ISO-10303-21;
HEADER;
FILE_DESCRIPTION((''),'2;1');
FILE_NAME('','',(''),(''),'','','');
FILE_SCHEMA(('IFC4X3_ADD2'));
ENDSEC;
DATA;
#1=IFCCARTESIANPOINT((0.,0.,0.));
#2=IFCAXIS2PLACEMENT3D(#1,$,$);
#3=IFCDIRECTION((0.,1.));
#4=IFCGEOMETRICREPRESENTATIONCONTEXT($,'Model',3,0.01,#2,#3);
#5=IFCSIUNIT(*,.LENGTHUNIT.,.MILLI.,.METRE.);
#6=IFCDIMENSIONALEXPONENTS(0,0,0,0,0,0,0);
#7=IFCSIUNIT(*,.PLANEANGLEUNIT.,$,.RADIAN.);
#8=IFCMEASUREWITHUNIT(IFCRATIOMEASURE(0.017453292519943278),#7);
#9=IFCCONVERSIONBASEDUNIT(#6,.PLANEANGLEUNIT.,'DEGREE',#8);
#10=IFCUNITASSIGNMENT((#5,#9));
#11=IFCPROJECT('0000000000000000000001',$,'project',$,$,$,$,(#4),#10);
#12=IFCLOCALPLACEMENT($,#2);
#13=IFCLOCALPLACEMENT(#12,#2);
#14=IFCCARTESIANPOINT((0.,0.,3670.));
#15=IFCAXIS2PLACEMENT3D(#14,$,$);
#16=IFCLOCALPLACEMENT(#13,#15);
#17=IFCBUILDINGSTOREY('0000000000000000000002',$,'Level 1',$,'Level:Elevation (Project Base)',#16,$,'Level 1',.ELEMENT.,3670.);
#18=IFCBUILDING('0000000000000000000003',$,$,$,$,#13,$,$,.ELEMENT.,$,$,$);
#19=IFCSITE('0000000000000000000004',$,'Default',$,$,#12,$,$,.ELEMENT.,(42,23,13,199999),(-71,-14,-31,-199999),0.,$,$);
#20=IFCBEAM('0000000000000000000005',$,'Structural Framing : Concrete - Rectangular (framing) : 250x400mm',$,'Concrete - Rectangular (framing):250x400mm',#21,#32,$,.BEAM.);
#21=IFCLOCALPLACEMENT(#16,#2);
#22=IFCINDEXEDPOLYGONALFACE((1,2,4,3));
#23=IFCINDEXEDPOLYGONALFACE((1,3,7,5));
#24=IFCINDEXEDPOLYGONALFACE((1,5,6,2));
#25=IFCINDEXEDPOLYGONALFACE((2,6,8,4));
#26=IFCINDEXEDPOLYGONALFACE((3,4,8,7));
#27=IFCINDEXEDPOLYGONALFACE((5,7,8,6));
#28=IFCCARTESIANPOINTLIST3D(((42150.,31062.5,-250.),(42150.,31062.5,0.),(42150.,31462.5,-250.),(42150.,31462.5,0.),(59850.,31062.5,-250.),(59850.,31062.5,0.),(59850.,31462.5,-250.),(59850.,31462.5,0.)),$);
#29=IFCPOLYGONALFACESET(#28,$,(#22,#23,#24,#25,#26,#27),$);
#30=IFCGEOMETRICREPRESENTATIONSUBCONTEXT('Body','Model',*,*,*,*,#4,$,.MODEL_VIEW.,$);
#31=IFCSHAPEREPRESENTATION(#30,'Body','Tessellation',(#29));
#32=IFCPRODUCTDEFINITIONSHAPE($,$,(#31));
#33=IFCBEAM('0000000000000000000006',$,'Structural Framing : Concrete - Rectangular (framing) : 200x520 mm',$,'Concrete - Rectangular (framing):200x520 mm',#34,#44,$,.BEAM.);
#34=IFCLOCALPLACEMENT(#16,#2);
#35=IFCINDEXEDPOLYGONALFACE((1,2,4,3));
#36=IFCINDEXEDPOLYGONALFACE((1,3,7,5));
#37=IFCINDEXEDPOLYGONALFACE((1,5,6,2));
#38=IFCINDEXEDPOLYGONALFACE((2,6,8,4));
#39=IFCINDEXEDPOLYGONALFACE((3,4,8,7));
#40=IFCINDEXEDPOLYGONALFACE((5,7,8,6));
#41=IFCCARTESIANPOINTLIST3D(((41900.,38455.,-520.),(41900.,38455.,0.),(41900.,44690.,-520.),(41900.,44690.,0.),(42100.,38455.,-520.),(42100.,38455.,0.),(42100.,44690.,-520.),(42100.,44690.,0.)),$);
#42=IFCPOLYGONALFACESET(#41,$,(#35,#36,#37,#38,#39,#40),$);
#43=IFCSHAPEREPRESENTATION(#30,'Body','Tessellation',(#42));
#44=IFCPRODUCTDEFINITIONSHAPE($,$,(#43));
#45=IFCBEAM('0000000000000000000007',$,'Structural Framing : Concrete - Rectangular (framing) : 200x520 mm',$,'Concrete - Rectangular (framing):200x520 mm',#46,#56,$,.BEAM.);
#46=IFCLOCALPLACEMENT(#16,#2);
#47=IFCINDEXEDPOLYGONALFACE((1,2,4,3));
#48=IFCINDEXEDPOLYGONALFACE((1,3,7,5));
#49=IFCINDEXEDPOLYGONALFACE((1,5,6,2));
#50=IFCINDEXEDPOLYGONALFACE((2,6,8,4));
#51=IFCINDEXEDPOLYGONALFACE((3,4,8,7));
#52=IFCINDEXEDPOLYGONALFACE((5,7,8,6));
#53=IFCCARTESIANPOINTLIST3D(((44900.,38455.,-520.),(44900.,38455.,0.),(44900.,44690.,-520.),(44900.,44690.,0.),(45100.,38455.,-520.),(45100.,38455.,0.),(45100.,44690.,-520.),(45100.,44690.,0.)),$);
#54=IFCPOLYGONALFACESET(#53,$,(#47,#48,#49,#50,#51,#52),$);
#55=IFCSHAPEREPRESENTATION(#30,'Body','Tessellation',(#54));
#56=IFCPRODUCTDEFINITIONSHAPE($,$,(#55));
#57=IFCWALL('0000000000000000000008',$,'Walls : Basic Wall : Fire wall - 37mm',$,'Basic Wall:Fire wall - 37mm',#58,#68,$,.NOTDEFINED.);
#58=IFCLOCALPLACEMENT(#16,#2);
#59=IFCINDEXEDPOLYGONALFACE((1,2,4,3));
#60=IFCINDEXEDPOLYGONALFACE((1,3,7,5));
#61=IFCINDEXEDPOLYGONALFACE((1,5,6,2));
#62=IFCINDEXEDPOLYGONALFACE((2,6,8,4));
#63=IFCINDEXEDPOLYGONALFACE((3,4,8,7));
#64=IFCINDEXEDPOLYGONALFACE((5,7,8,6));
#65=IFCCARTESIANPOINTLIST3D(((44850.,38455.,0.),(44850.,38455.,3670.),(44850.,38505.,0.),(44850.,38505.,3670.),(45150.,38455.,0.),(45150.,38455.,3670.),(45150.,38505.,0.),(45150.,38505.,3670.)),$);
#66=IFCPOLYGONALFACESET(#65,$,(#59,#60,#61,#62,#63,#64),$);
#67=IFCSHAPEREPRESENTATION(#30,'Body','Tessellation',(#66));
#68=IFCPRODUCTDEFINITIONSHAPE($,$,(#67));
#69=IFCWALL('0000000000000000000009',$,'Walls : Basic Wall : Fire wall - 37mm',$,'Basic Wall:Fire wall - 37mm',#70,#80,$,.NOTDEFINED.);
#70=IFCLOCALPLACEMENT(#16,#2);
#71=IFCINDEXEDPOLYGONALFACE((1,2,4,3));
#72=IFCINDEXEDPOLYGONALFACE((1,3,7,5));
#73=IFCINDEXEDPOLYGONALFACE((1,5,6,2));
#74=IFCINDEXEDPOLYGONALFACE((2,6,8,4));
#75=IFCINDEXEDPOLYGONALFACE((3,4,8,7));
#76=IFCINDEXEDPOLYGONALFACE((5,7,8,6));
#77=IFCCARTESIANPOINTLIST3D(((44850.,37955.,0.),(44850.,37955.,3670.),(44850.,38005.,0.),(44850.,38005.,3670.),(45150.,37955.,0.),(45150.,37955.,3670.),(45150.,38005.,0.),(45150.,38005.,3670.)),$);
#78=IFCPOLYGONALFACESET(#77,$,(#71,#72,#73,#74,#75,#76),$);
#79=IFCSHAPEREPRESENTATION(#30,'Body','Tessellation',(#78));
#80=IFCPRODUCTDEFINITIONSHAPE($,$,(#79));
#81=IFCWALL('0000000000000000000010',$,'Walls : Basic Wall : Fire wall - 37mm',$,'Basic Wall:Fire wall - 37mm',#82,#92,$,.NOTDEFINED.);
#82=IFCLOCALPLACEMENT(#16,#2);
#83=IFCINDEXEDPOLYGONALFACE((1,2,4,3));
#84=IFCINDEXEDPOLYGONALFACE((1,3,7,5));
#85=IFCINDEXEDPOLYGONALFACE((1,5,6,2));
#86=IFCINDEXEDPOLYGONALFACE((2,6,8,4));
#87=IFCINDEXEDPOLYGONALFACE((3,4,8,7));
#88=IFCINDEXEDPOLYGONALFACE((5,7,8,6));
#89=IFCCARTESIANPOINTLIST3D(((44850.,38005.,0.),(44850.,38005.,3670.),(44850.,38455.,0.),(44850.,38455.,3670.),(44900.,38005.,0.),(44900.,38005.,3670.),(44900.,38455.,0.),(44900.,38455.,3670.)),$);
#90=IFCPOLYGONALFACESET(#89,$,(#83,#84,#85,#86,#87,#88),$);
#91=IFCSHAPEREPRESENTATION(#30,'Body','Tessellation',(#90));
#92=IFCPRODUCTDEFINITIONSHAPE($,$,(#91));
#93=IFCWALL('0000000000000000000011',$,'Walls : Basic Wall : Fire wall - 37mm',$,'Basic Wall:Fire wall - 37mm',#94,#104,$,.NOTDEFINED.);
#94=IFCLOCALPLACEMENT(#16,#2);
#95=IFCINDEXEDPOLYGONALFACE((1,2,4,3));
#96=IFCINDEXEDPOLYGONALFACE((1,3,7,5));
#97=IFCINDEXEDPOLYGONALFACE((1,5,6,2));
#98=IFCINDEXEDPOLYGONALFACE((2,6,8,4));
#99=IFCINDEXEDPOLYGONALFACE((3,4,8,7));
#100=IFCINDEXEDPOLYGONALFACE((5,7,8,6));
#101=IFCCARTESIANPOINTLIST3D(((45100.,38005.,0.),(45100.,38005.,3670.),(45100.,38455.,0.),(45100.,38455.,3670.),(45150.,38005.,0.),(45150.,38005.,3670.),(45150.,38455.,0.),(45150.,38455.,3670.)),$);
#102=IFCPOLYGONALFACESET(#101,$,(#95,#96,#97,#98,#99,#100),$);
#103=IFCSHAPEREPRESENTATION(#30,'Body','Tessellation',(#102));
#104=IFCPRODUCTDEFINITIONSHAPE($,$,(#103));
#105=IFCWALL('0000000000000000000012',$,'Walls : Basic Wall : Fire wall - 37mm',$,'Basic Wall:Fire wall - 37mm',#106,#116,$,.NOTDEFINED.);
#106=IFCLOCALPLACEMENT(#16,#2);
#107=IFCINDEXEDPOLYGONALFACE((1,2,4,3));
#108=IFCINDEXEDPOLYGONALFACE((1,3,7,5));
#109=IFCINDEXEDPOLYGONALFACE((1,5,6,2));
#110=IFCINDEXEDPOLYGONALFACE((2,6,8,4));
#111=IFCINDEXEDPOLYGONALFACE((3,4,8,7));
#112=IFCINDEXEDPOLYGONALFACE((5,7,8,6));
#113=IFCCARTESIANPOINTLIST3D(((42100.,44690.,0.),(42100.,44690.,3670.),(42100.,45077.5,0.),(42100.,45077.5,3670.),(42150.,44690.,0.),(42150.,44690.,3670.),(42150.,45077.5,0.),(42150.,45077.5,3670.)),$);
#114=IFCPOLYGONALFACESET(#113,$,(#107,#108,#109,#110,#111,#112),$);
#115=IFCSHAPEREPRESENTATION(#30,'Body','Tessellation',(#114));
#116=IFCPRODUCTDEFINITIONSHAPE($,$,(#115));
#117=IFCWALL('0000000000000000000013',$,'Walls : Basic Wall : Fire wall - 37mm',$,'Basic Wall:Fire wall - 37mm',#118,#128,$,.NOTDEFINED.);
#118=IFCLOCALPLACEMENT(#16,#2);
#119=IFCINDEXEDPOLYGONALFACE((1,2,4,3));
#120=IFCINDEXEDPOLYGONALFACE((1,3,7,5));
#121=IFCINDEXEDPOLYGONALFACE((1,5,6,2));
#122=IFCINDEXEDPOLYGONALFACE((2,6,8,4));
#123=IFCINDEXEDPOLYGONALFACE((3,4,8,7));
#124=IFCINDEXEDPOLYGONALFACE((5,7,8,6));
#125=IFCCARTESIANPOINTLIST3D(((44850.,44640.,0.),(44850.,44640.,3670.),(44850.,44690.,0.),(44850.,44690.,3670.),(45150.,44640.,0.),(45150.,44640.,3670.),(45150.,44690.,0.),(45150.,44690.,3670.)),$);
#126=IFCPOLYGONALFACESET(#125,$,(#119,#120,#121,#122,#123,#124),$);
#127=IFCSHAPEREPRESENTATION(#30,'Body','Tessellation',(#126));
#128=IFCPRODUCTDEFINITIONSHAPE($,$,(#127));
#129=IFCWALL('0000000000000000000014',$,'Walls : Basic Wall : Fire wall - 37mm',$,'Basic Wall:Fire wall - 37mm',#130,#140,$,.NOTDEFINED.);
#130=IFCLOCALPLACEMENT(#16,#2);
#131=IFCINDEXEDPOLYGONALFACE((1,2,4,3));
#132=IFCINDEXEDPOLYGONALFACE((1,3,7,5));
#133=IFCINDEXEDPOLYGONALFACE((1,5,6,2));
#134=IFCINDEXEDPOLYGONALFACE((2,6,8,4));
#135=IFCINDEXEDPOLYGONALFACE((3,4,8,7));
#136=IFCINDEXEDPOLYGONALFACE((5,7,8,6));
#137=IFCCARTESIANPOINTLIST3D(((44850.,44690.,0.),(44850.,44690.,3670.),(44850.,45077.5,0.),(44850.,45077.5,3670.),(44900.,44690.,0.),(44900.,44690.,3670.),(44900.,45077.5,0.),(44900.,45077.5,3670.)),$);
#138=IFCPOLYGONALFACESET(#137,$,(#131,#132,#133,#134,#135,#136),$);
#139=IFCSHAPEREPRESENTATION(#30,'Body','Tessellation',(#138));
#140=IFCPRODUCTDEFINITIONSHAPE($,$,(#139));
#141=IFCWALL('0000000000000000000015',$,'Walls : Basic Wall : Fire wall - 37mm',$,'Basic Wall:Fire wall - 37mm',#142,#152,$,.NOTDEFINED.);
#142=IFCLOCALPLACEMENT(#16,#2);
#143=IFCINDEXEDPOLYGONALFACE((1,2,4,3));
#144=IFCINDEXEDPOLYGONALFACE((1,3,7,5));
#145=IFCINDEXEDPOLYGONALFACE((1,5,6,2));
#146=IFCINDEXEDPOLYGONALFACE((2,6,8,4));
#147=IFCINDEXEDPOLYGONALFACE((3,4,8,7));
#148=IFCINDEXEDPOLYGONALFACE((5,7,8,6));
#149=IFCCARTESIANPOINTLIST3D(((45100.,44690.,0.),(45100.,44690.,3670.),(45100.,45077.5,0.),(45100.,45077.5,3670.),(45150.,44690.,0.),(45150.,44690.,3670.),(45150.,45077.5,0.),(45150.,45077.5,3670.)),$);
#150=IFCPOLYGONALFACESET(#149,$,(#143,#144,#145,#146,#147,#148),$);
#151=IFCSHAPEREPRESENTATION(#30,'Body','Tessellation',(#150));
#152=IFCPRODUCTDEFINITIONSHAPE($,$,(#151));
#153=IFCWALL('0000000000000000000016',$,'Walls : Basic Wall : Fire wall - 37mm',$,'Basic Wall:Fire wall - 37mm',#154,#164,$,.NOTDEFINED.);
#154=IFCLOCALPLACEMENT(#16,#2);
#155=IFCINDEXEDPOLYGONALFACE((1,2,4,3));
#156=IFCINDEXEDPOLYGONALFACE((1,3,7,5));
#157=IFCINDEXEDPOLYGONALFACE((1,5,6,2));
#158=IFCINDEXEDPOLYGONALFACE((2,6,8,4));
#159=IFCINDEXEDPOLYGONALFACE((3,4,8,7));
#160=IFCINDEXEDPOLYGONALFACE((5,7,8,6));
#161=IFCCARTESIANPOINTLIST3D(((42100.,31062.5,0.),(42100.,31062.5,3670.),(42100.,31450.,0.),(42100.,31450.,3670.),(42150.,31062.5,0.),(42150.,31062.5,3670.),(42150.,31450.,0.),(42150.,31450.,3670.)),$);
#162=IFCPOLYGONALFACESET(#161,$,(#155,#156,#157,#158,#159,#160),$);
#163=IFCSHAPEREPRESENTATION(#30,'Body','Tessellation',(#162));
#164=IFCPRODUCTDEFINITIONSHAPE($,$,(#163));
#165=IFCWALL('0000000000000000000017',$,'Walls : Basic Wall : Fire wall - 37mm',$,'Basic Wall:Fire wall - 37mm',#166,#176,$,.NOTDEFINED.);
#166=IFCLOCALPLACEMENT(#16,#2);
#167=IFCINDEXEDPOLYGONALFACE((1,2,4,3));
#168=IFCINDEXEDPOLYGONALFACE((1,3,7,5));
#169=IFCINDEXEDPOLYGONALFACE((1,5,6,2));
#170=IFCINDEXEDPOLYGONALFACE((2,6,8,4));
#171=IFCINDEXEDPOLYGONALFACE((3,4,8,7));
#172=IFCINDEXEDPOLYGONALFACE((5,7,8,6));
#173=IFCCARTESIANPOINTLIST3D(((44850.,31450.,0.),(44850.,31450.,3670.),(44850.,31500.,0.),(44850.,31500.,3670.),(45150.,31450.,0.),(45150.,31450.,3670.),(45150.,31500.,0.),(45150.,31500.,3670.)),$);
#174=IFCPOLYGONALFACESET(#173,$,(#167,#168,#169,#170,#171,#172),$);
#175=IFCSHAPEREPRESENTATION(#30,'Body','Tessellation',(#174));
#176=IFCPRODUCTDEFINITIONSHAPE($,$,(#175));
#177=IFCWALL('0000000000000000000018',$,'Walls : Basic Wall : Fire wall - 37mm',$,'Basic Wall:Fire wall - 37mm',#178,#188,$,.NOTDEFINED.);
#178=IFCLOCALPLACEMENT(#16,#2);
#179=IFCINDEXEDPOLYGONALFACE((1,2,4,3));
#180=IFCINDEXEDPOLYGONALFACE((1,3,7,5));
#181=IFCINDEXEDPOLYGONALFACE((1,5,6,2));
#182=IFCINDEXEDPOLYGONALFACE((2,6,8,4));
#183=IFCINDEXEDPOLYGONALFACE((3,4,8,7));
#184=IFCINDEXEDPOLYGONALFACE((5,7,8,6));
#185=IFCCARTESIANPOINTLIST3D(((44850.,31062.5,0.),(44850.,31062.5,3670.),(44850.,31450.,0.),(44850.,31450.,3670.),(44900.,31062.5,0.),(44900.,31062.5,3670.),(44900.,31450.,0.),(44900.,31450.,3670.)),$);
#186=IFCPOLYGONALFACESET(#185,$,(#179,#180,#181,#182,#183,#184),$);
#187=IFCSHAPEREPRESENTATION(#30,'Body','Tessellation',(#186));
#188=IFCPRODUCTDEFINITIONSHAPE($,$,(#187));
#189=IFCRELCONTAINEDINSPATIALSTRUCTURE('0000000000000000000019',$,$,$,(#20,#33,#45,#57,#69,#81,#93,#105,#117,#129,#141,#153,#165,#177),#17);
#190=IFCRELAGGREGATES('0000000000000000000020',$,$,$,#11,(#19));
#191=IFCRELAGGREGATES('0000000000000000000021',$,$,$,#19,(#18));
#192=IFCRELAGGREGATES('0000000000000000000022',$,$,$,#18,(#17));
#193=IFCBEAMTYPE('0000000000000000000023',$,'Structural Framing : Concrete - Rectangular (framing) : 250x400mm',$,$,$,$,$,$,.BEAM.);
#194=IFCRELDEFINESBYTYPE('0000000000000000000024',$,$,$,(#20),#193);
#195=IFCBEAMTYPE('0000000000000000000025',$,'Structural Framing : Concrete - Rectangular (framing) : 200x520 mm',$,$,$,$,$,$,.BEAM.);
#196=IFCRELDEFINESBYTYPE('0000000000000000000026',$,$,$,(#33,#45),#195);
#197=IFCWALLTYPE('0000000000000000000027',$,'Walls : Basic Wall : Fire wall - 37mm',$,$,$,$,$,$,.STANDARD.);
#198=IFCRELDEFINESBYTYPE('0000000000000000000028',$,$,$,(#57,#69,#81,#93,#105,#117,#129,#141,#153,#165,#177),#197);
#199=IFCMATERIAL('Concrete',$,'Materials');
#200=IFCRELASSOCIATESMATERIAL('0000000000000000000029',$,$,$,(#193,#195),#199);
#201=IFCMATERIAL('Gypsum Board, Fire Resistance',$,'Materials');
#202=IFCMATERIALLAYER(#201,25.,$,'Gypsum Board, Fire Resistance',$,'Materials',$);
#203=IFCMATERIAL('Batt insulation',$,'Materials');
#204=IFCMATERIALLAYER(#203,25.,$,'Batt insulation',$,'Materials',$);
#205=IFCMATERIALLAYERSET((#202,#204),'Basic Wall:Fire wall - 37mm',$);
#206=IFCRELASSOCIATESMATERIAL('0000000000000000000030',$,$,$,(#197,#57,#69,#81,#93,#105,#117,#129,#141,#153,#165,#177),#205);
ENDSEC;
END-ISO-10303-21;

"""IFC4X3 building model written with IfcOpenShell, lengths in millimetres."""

from ifc_helpers import new_model, entity, si_unit, converted_unit, direction, frame, frame_2d, origin, origin_2d_with_axis, place, context, subcontext, project, spatial, rectangle, extrude, source, transform, mapped, material, layer, layer_set, material_profile, profile_set, type_object, type_shapes, element, save


model = new_model("IFC4X3")

# Units and contexts
model_context = context("Model", 3, precision=0.01, world=origin(), true_north=direction((0.0, 1.0)))
body_context = subcontext(model_context, "Body", "Model", "MODEL_VIEW")
ifc_project = project(units=[si_unit("LENGTHUNIT", "METRE", prefix="MILLI"), converted_unit("PLANEANGLEUNIT", "DEGREE", entity("IfcRatioMeasure", 0.017453292519943278), si_unit("PLANEANGLEUNIT", "RADIAN"), dimensions=[0, 0, 0, 0, 0, 0, 0])], contexts=[model_context])

# Site, building, storey
site_placement = place(None, origin())
site = spatial("IfcSite", under=ifc_project, at=site_placement, Name="Default", CompositionType="ELEMENT", RefLatitude=(42, 23, 13, 199999), RefLongitude=(-71, -14, -31, -199999), RefElevation=0.0)
building_placement = place(site_placement, origin())
building = spatial("IfcBuilding", under=site, at=building_placement, CompositionType="ELEMENT")
storey_placement = place(building_placement, frame((0.0, 0.0, 3670.0)))
storey = spatial("IfcBuildingStorey", under=building, at=storey_placement, Name="Level 1", ObjectType="Level:Elevation (Project Base)", LongName="Level 1", CompositionType="ELEMENT", Elevation=3670.0)

# Beams
ifc_material_1 = material(Name="Concrete", Category="Materials")
ifc_material_profile_1 = material_profile(ifc_material_1, rectangle(XDim=250.0, YDim=400.0, at=origin_2d_with_axis()), Name="250x400mm")
ifc_profile_set_1 = profile_set([ifc_material_profile_1], Name="250x400mm")
beam_type_1 = type_object("IfcBeamType", Name="Structural Framing : Concrete - Rectangular (framing) : 250x400mm", PredefinedType="BEAM", material=ifc_profile_set_1)
shared_shape_1 = source(origin(), body_context, "Body", "SweptSolid", [
    extrude(rectangle(XDim=250.0, YDim=400.0, at=origin_2d_with_axis()), frame((-8550.0, 0.0, 0.0), z_axis=(1.0, 0.0, 0.0), x_axis=(0.0, 0.0, -1.0)), (0.0, 0.0, 1.0), 17700.0),
])
type_shapes(beam_type_1, [shared_shape_1])
beam_placement = place(storey_placement, frame((50700.0, 31262.5, -125.0)))
element("IfcBeam", 1, at=beam_placement, inside=storey, type_object=beam_type_1, Name="Structural Framing : Concrete - Rectangular (framing) : 250x400mm", ObjectType="Concrete - Rectangular (framing):250x400mm", PredefinedType="BEAM", context=body_context, shape_type="MappedRepresentation", body=[
    mapped(shared_shape_1, transform((0.0, 0.0, 0.0), scale=1.0)),
])
ifc_material_profile_2 = material_profile(ifc_material_1, rectangle(XDim=520.0, YDim=200.0, at=frame_2d((0.0, 0.0), x_axis=(1.0, 0.0))), Name="200x520 mm")
ifc_profile_set_2 = profile_set([ifc_material_profile_2], Name="200x520 mm")
beam_type_2 = type_object("IfcBeamType", Name="Structural Framing : Concrete - Rectangular (framing) : 200x520 mm", PredefinedType="BEAM", material=ifc_profile_set_2)
shared_shape_2 = source(origin(), body_context, "Body", "SweptSolid", [
    extrude(rectangle(XDim=520.0, YDim=200.0, at=frame_2d((0.0, 0.0), x_axis=(1.0, 0.0))), frame((-1350.0, 0.0, 0.0), z_axis=(1.0, 0.0, 0.0), x_axis=(0.0, 0.0, -1.0)), (0.0, 0.0, 1.0), 6235.0),
])
type_shapes(beam_type_2, [shared_shape_2])
for number, where, z_axis, x_axis, name in (
    (2, (42000.0, 43340.0, -260.0), (0.0, 0.0, 1.0), (0.0, -1.0, 0.0), "Structural Framing : Concrete - Rectangular (framing) : 200x520 mm"),
    (3, (45000.0, 43340.0, -260.0), (0.0, 0.0, 1.0), (0.0, -1.0, 0.0), "Structural Framing : Concrete - Rectangular (framing) : 200x520 mm"),
):
    element("IfcBeam", number, at=place(storey_placement, frame(where, z_axis=z_axis, x_axis=x_axis)), inside=storey, type_object=beam_type_2, Name=name, ObjectType="Concrete - Rectangular (framing):200x520 mm", PredefinedType="BEAM", context=body_context, shape_type="MappedRepresentation", body=[
        mapped(shared_shape_2, transform((0.0, 0.0, 0.0), scale=1.0)),
    ])

# Walls
ifc_material_2 = material(Name="Gypsum Board, Fire Resistance", Category="Materials")
ifc_layer_1 = layer(ifc_material_2, 25.0, Name="Gypsum Board, Fire Resistance", Category="Materials")
ifc_material_3 = material(Name="Batt insulation", Category="Materials")
ifc_layer_2 = layer(ifc_material_3, 25.0, Name="Batt insulation", Category="Materials")
ifc_layer_set = layer_set([ifc_layer_1, ifc_layer_2], Name="Basic Wall:Fire wall - 37mm")
wall_type = type_object("IfcWallType", Name="Walls : Basic Wall : Fire wall - 37mm", PredefinedType="STANDARD", material=ifc_layer_set)
for number, where, name in (
    (4, (44850.0, 38480.0, 0.0), "Walls : Basic Wall : Fire wall - 37mm"),
    (5, (44850.0, 37980.0, 0.0), "Walls : Basic Wall : Fire wall - 37mm"),
):
    element("IfcWall", number, at=place(storey_placement, frame(where)), inside=storey, type_object=wall_type, material=ifc_layer_set, Name=name, ObjectType="Basic Wall:Fire wall - 37mm", PredefinedType="NOTDEFINED", context=body_context, shape_type="SweptSolid", body=[
        extrude(rectangle(XDim=300.0, YDim=50.0, at=frame_2d((150.0, 0.0), x_axis=(-1.0, 0.0))), origin(), (0.0, 0.0, 1.0), 3670.0),
    ])
for number, where, z_axis, x_axis, name in (
    (6, (44875.0, 38455.0, 0.0), (0.0, 0.0, 1.0), (0.0, -1.0, 0.0), "Walls : Basic Wall : Fire wall - 37mm"),
    (7, (45125.0, 38455.0, 0.0), (0.0, 0.0, 1.0), (0.0, -1.0, 0.0), "Walls : Basic Wall : Fire wall - 37mm"),
):
    element("IfcWall", number, at=place(storey_placement, frame(where, z_axis=z_axis, x_axis=x_axis)), inside=storey, type_object=wall_type, material=ifc_layer_set, Name=name, ObjectType="Basic Wall:Fire wall - 37mm", PredefinedType="NOTDEFINED", context=body_context, shape_type="SweptSolid", body=[
        extrude(rectangle(XDim=450.0, YDim=50.0, at=frame_2d((225.0, 0.0), x_axis=(-1.0, 0.0))), origin(), (0.0, 0.0, 1.0), 3670.0),
    ])
wall_1_placement = place(storey_placement, frame((42125.0, 45077.5, 0.0), z_axis=(0.0, 0.0, 1.0), x_axis=(0.0, -1.0, 0.0)))
element("IfcWall", 8, at=wall_1_placement, inside=storey, type_object=wall_type, material=ifc_layer_set, Name="Walls : Basic Wall : Fire wall - 37mm", ObjectType="Basic Wall:Fire wall - 37mm", PredefinedType="NOTDEFINED", context=body_context, shape_type="SweptSolid", body=[
    extrude(rectangle(XDim=387.5, YDim=50.0, at=frame_2d((193.8, 0.0), x_axis=(-1.0, 0.0))), origin(), (0.0, 0.0, 1.0), 3670.0),
])
wall_2_placement = place(storey_placement, frame((44850.0, 44665.0, 0.0)))
element("IfcWall", 9, at=wall_2_placement, inside=storey, type_object=wall_type, material=ifc_layer_set, Name="Walls : Basic Wall : Fire wall - 37mm", ObjectType="Basic Wall:Fire wall - 37mm", PredefinedType="NOTDEFINED", context=body_context, shape_type="SweptSolid", body=[
    extrude(rectangle(XDim=300.0, YDim=50.0, at=frame_2d((150.0, 0.0), x_axis=(-1.0, 0.0))), origin(), (0.0, 0.0, 1.0), 3670.0),
])
for number, where, z_axis, x_axis, name in (
    (10, (44875.0, 45077.5, 0.0), (0.0, 0.0, 1.0), (0.0, -1.0, 0.0), "Walls : Basic Wall : Fire wall - 37mm"),
    (11, (45125.0, 45077.5, 0.0), (0.0, 0.0, 1.0), (0.0, -1.0, 0.0), "Walls : Basic Wall : Fire wall - 37mm"),
):
    element("IfcWall", number, at=place(storey_placement, frame(where, z_axis=z_axis, x_axis=x_axis)), inside=storey, type_object=wall_type, material=ifc_layer_set, Name=name, ObjectType="Basic Wall:Fire wall - 37mm", PredefinedType="NOTDEFINED", context=body_context, shape_type="SweptSolid", body=[
        extrude(rectangle(XDim=387.5, YDim=50.0, at=frame_2d((193.8, 0.0), x_axis=(-1.0, 0.0))), origin(), (0.0, 0.0, 1.0), 3670.0),
    ])
wall_3_placement = place(storey_placement, frame((42125.0, 31450.0, 0.0), z_axis=(0.0, 0.0, 1.0), x_axis=(0.0, -1.0, 0.0)))
element("IfcWall", 12, at=wall_3_placement, inside=storey, type_object=wall_type, material=ifc_layer_set, Name="Walls : Basic Wall : Fire wall - 37mm", ObjectType="Basic Wall:Fire wall - 37mm", PredefinedType="NOTDEFINED", context=body_context, shape_type="SweptSolid", body=[
    extrude(rectangle(XDim=387.5, YDim=50.0, at=frame_2d((193.7, 0.0), x_axis=(-1.0, 0.0))), origin(), (0.0, 0.0, 1.0), 3670.0),
])
wall_4_placement = place(storey_placement, frame((44850.0, 31475.0, 0.0)))
element("IfcWall", 13, at=wall_4_placement, inside=storey, type_object=wall_type, material=ifc_layer_set, Name="Walls : Basic Wall : Fire wall - 37mm", ObjectType="Basic Wall:Fire wall - 37mm", PredefinedType="NOTDEFINED", context=body_context, shape_type="SweptSolid", body=[
    extrude(rectangle(XDim=300.0, YDim=50.0, at=frame_2d((150.0, 0.0), x_axis=(-1.0, 0.0))), origin(), (0.0, 0.0, 1.0), 3670.0),
])
for number, where, z_axis, x_axis, name in (
    (14, (44875.0, 31450.0, 0.0), (0.0, 0.0, 1.0), (0.0, -1.0, 0.0), "Walls : Basic Wall : Fire wall - 37mm"),
):
    element("IfcWall", number, at=place(storey_placement, frame(where, z_axis=z_axis, x_axis=x_axis)), inside=storey, type_object=wall_type, material=ifc_layer_set, Name=name, ObjectType="Basic Wall:Fire wall - 37mm", PredefinedType="NOTDEFINED", context=body_context, shape_type="SweptSolid", body=[
        extrude(rectangle(XDim=387.5, YDim=50.0, at=frame_2d((193.7, 0.0), x_axis=(-1.0, 0.0))), origin(), (0.0, 0.0, 1.0), 3670.0),
    ])

save(model, "model.ifc")
